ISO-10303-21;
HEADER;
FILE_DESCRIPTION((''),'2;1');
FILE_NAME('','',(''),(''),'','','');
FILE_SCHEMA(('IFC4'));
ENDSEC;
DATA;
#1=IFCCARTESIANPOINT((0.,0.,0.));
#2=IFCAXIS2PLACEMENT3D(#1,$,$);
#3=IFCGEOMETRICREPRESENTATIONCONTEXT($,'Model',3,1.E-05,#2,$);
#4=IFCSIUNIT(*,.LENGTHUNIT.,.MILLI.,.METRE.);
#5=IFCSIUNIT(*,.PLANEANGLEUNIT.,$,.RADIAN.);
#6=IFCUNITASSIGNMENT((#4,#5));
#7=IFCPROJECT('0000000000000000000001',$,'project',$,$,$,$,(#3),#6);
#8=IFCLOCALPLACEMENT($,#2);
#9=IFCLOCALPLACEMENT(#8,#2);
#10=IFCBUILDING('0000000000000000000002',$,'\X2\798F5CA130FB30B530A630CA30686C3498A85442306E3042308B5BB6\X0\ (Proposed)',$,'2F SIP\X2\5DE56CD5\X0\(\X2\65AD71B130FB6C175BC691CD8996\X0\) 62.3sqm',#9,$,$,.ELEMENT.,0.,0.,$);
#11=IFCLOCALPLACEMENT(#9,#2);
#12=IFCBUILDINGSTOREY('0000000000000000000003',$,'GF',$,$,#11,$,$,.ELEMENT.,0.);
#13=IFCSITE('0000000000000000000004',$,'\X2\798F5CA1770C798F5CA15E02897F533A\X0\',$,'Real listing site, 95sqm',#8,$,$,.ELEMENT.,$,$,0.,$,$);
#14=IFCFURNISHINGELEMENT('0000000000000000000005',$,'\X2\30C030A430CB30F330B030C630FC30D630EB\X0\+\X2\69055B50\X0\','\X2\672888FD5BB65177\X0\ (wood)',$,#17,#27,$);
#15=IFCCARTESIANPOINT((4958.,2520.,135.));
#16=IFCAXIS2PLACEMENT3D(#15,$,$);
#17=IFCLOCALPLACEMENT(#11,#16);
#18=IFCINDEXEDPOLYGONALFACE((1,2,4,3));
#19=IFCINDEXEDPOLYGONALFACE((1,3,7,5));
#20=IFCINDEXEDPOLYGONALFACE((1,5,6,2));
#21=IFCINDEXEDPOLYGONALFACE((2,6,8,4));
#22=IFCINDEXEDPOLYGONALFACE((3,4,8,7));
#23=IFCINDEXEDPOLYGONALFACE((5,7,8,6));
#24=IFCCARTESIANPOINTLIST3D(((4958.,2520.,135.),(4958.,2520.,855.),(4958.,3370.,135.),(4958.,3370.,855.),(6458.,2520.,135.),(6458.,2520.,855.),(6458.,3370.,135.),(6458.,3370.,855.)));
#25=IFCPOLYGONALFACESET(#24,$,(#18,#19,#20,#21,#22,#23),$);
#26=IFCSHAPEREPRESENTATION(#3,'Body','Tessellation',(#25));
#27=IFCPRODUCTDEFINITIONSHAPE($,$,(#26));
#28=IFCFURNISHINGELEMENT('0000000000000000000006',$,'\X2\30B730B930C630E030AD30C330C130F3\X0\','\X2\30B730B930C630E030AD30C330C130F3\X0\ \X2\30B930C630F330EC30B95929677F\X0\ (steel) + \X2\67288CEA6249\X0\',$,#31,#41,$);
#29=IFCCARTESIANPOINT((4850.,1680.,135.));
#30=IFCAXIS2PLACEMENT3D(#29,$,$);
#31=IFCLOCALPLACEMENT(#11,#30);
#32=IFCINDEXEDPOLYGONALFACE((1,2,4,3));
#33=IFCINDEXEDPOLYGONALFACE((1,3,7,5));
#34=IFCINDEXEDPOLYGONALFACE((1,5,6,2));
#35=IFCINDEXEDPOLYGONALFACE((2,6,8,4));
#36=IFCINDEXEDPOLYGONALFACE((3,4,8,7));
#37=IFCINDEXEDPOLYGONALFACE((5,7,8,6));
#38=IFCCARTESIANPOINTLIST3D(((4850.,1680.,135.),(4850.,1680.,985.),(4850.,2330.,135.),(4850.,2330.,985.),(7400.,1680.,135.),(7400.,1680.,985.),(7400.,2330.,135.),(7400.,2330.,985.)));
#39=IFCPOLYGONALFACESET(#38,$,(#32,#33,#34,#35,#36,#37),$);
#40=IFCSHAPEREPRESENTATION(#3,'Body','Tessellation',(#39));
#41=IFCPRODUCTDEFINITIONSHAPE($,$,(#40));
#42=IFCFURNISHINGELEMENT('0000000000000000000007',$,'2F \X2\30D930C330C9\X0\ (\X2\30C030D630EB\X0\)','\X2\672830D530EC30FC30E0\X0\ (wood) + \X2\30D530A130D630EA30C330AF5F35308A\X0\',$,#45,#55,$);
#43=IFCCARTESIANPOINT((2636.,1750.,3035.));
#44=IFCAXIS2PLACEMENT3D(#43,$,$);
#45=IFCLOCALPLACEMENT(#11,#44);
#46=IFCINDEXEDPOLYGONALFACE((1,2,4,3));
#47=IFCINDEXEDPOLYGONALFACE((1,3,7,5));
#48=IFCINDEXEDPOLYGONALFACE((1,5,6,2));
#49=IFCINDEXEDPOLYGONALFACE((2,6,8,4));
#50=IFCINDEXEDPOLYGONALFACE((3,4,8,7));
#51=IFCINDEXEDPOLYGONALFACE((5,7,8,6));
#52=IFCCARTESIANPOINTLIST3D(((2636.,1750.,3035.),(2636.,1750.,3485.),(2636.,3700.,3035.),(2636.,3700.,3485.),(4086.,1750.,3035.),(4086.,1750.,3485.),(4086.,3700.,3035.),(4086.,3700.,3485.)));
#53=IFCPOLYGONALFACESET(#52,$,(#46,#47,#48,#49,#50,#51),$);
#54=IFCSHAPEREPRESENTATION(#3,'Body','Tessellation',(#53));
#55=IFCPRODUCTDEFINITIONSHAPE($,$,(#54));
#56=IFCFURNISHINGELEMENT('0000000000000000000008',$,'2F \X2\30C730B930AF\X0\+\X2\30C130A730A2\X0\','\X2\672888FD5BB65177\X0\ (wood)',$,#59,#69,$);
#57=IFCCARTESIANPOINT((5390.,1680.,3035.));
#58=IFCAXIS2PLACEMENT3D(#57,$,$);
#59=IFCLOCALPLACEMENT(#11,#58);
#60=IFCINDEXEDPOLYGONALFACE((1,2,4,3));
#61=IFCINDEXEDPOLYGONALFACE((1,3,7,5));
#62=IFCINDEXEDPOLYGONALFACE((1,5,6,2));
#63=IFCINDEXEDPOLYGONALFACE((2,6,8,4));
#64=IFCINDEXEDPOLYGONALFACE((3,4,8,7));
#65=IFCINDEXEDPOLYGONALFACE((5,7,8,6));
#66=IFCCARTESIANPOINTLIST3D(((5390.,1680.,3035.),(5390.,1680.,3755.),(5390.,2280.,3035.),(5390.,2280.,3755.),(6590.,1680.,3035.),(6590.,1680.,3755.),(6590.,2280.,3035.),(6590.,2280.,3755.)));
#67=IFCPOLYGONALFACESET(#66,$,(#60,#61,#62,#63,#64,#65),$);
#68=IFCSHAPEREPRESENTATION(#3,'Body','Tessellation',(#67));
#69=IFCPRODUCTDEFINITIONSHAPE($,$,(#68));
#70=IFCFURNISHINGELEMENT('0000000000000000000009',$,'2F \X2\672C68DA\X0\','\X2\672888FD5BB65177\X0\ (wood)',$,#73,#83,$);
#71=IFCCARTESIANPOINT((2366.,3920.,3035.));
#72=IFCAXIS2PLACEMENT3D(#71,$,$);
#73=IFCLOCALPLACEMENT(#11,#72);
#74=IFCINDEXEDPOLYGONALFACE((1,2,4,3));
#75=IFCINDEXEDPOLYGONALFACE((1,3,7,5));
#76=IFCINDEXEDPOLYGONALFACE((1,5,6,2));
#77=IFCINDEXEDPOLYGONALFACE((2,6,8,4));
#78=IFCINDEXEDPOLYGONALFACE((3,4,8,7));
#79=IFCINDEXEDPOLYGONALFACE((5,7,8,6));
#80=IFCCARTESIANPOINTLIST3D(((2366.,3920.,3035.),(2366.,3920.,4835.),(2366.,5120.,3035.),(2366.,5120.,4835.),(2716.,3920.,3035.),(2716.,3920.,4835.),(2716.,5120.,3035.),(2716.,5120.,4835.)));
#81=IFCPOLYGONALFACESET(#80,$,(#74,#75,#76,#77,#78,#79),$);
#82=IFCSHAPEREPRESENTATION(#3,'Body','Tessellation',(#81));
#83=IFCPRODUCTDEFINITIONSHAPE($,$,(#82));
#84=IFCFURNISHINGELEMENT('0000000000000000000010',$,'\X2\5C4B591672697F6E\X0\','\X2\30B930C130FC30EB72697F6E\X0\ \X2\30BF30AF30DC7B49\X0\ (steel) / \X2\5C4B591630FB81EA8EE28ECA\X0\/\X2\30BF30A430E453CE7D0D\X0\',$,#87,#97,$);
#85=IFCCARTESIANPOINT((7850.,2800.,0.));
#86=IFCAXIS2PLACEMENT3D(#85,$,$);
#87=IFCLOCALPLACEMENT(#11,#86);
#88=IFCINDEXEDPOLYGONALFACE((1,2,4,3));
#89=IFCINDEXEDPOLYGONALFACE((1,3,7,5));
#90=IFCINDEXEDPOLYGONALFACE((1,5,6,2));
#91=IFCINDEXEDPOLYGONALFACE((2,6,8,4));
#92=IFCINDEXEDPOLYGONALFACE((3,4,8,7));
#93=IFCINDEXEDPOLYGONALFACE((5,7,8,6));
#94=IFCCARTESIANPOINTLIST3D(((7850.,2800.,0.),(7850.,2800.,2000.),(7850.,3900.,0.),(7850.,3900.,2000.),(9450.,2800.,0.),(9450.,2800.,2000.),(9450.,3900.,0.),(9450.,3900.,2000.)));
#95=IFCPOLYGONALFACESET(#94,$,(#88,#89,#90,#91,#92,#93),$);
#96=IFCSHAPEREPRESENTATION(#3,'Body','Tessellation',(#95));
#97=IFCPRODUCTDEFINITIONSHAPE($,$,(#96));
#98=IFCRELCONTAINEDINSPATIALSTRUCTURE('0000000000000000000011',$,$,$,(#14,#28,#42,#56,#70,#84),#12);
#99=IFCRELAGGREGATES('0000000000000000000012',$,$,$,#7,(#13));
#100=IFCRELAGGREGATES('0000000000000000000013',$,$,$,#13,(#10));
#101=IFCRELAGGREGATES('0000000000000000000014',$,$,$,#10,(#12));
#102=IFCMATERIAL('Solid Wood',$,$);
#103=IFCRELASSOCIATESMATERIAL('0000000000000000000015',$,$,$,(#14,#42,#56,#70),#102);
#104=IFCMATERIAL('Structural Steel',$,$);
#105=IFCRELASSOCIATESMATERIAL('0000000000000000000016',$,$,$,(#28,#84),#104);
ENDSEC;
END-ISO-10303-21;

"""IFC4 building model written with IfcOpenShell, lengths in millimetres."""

from ifc_helpers import new_model, si_unit, frame, frame_2d, origin, place, context, project, spatial, rectangle, extrude, material, element, save


model = new_model("IFC4")

# Units and contexts
model_context = context("Model", 3, precision=1e-05, world=origin())
ifc_project = project(units=[si_unit("LENGTHUNIT", "METRE", prefix="MILLI"), si_unit("PLANEANGLEUNIT", "RADIAN")], contexts=[model_context])

# Site, building, storey
site_placement = place(None, origin())
site = spatial("IfcSite", under=ifc_project, at=site_placement, Name="福岡県福岡市西区", ObjectType="Real listing site, 95sqm", CompositionType="ELEMENT", RefElevation=0.0)
building_placement = place(site_placement, origin())
building = spatial("IfcBuilding", under=site, at=building_placement, Name="福岡・サウナと水風呂のある家 (Proposed)", ObjectType="2F SIP工法(断熱・気密重視) 62.3sqm", CompositionType="ELEMENT", ElevationOfRefHeight=0.0, ElevationOfTerrain=0.0)
storey_placement = place(building_placement, origin())
storey = spatial("IfcBuildingStorey", under=building, at=storey_placement, Name="GF", CompositionType="ELEMENT", Elevation=0.0)

# Shared definitions
ifc_material_1 = material(Name="Solid Wood")

# Shared definitions
ifc_material_2 = material(Name="Structural Steel")

# Furnishing elements
furnishing_1_placement = place(storey_placement, frame((4958.0, 2520.0, 135.0)))
element("IfcFurnishingElement", 1, at=furnishing_1_placement, inside=storey, material=ifc_material_1, Name="ダイニングテーブル+椅子", Description="木製家具 (wood)", context=model_context, shape_type="SweptSolid", body=[
    extrude(rectangle(XDim=1500.0, YDim=850.0, at=frame_2d((750.0, 425.0))), frame((4958.0, 2520.0, 135.0)), (0.0, 0.0, 1.0), 720.0),
])
furnishing_2_placement = place(storey_placement, frame((4850.0, 1680.0, 135.0)))
element("IfcFurnishingElement", 2, at=furnishing_2_placement, inside=storey, material=ifc_material_2, Name="システムキッチン", Description="システムキッチン ステンレス天板 (steel) + 木質扉", context=model_context, shape_type="SweptSolid", body=[
    extrude(rectangle(XDim=2550.0, YDim=650.0, at=frame_2d((1275.0, 325.0))), frame((4850.0, 1680.0, 135.0)), (0.0, 0.0, 1.0), 850.0),
])
furnishing_3_placement = place(storey_placement, frame((2636.0, 1750.0, 3035.0)))
element("IfcFurnishingElement", 3, at=furnishing_3_placement, inside=storey, material=ifc_material_1, Name="2F ベッド (ダブル)", Description="木フレーム (wood) + ファブリック張り", context=model_context, shape_type="SweptSolid", body=[
    extrude(rectangle(XDim=1450.0, YDim=1950.0, at=frame_2d((725.0, 975.0))), frame((2636.0, 1750.0, 3035.0)), (0.0, 0.0, 1.0), 450.0),
])
furnishing_4_placement = place(storey_placement, frame((5390.0, 1680.0, 3035.0)))
element("IfcFurnishingElement", 4, at=furnishing_4_placement, inside=storey, material=ifc_material_1, Name="2F デスク+チェア", Description="木製家具 (wood)", context=model_context, shape_type="SweptSolid", body=[
    extrude(rectangle(XDim=1200.0, YDim=600.0, at=frame_2d((600.0, 300.0))), frame((5390.0, 1680.0, 3035.0)), (0.0, 0.0, 1.0), 720.0),
])
furnishing_5_placement = place(storey_placement, frame((2366.0, 3920.0, 3035.0)))
element("IfcFurnishingElement", 5, at=furnishing_5_placement, inside=storey, material=ifc_material_1, Name="2F 本棚", Description="木製家具 (wood)", context=model_context, shape_type="SweptSolid", body=[
    extrude(rectangle(XDim=350.0, YDim=1200.0, at=frame_2d((175.0, 600.0))), frame((2366.0, 3920.0, 3035.0)), (0.0, 0.0, 1.0), 1800.0),
])
furnishing_6_placement = place(storey_placement, frame((7850.0, 2800.0, 0.0)))
element("IfcFurnishingElement", 6, at=furnishing_6_placement, inside=storey, material=ifc_material_2, Name="屋外物置", Description="スチール物置 タクボ等 (steel) / 屋外・自転車/タイヤ収納", context=model_context, shape_type="SweptSolid", body=[
    extrude(rectangle(XDim=1600.0, YDim=1100.0, at=frame_2d((800.0, 550.0))), frame((7850.0, 2800.0, 0.0)), (0.0, 0.0, 1.0), 2000.0),
])

save(model, "model.ifc")
